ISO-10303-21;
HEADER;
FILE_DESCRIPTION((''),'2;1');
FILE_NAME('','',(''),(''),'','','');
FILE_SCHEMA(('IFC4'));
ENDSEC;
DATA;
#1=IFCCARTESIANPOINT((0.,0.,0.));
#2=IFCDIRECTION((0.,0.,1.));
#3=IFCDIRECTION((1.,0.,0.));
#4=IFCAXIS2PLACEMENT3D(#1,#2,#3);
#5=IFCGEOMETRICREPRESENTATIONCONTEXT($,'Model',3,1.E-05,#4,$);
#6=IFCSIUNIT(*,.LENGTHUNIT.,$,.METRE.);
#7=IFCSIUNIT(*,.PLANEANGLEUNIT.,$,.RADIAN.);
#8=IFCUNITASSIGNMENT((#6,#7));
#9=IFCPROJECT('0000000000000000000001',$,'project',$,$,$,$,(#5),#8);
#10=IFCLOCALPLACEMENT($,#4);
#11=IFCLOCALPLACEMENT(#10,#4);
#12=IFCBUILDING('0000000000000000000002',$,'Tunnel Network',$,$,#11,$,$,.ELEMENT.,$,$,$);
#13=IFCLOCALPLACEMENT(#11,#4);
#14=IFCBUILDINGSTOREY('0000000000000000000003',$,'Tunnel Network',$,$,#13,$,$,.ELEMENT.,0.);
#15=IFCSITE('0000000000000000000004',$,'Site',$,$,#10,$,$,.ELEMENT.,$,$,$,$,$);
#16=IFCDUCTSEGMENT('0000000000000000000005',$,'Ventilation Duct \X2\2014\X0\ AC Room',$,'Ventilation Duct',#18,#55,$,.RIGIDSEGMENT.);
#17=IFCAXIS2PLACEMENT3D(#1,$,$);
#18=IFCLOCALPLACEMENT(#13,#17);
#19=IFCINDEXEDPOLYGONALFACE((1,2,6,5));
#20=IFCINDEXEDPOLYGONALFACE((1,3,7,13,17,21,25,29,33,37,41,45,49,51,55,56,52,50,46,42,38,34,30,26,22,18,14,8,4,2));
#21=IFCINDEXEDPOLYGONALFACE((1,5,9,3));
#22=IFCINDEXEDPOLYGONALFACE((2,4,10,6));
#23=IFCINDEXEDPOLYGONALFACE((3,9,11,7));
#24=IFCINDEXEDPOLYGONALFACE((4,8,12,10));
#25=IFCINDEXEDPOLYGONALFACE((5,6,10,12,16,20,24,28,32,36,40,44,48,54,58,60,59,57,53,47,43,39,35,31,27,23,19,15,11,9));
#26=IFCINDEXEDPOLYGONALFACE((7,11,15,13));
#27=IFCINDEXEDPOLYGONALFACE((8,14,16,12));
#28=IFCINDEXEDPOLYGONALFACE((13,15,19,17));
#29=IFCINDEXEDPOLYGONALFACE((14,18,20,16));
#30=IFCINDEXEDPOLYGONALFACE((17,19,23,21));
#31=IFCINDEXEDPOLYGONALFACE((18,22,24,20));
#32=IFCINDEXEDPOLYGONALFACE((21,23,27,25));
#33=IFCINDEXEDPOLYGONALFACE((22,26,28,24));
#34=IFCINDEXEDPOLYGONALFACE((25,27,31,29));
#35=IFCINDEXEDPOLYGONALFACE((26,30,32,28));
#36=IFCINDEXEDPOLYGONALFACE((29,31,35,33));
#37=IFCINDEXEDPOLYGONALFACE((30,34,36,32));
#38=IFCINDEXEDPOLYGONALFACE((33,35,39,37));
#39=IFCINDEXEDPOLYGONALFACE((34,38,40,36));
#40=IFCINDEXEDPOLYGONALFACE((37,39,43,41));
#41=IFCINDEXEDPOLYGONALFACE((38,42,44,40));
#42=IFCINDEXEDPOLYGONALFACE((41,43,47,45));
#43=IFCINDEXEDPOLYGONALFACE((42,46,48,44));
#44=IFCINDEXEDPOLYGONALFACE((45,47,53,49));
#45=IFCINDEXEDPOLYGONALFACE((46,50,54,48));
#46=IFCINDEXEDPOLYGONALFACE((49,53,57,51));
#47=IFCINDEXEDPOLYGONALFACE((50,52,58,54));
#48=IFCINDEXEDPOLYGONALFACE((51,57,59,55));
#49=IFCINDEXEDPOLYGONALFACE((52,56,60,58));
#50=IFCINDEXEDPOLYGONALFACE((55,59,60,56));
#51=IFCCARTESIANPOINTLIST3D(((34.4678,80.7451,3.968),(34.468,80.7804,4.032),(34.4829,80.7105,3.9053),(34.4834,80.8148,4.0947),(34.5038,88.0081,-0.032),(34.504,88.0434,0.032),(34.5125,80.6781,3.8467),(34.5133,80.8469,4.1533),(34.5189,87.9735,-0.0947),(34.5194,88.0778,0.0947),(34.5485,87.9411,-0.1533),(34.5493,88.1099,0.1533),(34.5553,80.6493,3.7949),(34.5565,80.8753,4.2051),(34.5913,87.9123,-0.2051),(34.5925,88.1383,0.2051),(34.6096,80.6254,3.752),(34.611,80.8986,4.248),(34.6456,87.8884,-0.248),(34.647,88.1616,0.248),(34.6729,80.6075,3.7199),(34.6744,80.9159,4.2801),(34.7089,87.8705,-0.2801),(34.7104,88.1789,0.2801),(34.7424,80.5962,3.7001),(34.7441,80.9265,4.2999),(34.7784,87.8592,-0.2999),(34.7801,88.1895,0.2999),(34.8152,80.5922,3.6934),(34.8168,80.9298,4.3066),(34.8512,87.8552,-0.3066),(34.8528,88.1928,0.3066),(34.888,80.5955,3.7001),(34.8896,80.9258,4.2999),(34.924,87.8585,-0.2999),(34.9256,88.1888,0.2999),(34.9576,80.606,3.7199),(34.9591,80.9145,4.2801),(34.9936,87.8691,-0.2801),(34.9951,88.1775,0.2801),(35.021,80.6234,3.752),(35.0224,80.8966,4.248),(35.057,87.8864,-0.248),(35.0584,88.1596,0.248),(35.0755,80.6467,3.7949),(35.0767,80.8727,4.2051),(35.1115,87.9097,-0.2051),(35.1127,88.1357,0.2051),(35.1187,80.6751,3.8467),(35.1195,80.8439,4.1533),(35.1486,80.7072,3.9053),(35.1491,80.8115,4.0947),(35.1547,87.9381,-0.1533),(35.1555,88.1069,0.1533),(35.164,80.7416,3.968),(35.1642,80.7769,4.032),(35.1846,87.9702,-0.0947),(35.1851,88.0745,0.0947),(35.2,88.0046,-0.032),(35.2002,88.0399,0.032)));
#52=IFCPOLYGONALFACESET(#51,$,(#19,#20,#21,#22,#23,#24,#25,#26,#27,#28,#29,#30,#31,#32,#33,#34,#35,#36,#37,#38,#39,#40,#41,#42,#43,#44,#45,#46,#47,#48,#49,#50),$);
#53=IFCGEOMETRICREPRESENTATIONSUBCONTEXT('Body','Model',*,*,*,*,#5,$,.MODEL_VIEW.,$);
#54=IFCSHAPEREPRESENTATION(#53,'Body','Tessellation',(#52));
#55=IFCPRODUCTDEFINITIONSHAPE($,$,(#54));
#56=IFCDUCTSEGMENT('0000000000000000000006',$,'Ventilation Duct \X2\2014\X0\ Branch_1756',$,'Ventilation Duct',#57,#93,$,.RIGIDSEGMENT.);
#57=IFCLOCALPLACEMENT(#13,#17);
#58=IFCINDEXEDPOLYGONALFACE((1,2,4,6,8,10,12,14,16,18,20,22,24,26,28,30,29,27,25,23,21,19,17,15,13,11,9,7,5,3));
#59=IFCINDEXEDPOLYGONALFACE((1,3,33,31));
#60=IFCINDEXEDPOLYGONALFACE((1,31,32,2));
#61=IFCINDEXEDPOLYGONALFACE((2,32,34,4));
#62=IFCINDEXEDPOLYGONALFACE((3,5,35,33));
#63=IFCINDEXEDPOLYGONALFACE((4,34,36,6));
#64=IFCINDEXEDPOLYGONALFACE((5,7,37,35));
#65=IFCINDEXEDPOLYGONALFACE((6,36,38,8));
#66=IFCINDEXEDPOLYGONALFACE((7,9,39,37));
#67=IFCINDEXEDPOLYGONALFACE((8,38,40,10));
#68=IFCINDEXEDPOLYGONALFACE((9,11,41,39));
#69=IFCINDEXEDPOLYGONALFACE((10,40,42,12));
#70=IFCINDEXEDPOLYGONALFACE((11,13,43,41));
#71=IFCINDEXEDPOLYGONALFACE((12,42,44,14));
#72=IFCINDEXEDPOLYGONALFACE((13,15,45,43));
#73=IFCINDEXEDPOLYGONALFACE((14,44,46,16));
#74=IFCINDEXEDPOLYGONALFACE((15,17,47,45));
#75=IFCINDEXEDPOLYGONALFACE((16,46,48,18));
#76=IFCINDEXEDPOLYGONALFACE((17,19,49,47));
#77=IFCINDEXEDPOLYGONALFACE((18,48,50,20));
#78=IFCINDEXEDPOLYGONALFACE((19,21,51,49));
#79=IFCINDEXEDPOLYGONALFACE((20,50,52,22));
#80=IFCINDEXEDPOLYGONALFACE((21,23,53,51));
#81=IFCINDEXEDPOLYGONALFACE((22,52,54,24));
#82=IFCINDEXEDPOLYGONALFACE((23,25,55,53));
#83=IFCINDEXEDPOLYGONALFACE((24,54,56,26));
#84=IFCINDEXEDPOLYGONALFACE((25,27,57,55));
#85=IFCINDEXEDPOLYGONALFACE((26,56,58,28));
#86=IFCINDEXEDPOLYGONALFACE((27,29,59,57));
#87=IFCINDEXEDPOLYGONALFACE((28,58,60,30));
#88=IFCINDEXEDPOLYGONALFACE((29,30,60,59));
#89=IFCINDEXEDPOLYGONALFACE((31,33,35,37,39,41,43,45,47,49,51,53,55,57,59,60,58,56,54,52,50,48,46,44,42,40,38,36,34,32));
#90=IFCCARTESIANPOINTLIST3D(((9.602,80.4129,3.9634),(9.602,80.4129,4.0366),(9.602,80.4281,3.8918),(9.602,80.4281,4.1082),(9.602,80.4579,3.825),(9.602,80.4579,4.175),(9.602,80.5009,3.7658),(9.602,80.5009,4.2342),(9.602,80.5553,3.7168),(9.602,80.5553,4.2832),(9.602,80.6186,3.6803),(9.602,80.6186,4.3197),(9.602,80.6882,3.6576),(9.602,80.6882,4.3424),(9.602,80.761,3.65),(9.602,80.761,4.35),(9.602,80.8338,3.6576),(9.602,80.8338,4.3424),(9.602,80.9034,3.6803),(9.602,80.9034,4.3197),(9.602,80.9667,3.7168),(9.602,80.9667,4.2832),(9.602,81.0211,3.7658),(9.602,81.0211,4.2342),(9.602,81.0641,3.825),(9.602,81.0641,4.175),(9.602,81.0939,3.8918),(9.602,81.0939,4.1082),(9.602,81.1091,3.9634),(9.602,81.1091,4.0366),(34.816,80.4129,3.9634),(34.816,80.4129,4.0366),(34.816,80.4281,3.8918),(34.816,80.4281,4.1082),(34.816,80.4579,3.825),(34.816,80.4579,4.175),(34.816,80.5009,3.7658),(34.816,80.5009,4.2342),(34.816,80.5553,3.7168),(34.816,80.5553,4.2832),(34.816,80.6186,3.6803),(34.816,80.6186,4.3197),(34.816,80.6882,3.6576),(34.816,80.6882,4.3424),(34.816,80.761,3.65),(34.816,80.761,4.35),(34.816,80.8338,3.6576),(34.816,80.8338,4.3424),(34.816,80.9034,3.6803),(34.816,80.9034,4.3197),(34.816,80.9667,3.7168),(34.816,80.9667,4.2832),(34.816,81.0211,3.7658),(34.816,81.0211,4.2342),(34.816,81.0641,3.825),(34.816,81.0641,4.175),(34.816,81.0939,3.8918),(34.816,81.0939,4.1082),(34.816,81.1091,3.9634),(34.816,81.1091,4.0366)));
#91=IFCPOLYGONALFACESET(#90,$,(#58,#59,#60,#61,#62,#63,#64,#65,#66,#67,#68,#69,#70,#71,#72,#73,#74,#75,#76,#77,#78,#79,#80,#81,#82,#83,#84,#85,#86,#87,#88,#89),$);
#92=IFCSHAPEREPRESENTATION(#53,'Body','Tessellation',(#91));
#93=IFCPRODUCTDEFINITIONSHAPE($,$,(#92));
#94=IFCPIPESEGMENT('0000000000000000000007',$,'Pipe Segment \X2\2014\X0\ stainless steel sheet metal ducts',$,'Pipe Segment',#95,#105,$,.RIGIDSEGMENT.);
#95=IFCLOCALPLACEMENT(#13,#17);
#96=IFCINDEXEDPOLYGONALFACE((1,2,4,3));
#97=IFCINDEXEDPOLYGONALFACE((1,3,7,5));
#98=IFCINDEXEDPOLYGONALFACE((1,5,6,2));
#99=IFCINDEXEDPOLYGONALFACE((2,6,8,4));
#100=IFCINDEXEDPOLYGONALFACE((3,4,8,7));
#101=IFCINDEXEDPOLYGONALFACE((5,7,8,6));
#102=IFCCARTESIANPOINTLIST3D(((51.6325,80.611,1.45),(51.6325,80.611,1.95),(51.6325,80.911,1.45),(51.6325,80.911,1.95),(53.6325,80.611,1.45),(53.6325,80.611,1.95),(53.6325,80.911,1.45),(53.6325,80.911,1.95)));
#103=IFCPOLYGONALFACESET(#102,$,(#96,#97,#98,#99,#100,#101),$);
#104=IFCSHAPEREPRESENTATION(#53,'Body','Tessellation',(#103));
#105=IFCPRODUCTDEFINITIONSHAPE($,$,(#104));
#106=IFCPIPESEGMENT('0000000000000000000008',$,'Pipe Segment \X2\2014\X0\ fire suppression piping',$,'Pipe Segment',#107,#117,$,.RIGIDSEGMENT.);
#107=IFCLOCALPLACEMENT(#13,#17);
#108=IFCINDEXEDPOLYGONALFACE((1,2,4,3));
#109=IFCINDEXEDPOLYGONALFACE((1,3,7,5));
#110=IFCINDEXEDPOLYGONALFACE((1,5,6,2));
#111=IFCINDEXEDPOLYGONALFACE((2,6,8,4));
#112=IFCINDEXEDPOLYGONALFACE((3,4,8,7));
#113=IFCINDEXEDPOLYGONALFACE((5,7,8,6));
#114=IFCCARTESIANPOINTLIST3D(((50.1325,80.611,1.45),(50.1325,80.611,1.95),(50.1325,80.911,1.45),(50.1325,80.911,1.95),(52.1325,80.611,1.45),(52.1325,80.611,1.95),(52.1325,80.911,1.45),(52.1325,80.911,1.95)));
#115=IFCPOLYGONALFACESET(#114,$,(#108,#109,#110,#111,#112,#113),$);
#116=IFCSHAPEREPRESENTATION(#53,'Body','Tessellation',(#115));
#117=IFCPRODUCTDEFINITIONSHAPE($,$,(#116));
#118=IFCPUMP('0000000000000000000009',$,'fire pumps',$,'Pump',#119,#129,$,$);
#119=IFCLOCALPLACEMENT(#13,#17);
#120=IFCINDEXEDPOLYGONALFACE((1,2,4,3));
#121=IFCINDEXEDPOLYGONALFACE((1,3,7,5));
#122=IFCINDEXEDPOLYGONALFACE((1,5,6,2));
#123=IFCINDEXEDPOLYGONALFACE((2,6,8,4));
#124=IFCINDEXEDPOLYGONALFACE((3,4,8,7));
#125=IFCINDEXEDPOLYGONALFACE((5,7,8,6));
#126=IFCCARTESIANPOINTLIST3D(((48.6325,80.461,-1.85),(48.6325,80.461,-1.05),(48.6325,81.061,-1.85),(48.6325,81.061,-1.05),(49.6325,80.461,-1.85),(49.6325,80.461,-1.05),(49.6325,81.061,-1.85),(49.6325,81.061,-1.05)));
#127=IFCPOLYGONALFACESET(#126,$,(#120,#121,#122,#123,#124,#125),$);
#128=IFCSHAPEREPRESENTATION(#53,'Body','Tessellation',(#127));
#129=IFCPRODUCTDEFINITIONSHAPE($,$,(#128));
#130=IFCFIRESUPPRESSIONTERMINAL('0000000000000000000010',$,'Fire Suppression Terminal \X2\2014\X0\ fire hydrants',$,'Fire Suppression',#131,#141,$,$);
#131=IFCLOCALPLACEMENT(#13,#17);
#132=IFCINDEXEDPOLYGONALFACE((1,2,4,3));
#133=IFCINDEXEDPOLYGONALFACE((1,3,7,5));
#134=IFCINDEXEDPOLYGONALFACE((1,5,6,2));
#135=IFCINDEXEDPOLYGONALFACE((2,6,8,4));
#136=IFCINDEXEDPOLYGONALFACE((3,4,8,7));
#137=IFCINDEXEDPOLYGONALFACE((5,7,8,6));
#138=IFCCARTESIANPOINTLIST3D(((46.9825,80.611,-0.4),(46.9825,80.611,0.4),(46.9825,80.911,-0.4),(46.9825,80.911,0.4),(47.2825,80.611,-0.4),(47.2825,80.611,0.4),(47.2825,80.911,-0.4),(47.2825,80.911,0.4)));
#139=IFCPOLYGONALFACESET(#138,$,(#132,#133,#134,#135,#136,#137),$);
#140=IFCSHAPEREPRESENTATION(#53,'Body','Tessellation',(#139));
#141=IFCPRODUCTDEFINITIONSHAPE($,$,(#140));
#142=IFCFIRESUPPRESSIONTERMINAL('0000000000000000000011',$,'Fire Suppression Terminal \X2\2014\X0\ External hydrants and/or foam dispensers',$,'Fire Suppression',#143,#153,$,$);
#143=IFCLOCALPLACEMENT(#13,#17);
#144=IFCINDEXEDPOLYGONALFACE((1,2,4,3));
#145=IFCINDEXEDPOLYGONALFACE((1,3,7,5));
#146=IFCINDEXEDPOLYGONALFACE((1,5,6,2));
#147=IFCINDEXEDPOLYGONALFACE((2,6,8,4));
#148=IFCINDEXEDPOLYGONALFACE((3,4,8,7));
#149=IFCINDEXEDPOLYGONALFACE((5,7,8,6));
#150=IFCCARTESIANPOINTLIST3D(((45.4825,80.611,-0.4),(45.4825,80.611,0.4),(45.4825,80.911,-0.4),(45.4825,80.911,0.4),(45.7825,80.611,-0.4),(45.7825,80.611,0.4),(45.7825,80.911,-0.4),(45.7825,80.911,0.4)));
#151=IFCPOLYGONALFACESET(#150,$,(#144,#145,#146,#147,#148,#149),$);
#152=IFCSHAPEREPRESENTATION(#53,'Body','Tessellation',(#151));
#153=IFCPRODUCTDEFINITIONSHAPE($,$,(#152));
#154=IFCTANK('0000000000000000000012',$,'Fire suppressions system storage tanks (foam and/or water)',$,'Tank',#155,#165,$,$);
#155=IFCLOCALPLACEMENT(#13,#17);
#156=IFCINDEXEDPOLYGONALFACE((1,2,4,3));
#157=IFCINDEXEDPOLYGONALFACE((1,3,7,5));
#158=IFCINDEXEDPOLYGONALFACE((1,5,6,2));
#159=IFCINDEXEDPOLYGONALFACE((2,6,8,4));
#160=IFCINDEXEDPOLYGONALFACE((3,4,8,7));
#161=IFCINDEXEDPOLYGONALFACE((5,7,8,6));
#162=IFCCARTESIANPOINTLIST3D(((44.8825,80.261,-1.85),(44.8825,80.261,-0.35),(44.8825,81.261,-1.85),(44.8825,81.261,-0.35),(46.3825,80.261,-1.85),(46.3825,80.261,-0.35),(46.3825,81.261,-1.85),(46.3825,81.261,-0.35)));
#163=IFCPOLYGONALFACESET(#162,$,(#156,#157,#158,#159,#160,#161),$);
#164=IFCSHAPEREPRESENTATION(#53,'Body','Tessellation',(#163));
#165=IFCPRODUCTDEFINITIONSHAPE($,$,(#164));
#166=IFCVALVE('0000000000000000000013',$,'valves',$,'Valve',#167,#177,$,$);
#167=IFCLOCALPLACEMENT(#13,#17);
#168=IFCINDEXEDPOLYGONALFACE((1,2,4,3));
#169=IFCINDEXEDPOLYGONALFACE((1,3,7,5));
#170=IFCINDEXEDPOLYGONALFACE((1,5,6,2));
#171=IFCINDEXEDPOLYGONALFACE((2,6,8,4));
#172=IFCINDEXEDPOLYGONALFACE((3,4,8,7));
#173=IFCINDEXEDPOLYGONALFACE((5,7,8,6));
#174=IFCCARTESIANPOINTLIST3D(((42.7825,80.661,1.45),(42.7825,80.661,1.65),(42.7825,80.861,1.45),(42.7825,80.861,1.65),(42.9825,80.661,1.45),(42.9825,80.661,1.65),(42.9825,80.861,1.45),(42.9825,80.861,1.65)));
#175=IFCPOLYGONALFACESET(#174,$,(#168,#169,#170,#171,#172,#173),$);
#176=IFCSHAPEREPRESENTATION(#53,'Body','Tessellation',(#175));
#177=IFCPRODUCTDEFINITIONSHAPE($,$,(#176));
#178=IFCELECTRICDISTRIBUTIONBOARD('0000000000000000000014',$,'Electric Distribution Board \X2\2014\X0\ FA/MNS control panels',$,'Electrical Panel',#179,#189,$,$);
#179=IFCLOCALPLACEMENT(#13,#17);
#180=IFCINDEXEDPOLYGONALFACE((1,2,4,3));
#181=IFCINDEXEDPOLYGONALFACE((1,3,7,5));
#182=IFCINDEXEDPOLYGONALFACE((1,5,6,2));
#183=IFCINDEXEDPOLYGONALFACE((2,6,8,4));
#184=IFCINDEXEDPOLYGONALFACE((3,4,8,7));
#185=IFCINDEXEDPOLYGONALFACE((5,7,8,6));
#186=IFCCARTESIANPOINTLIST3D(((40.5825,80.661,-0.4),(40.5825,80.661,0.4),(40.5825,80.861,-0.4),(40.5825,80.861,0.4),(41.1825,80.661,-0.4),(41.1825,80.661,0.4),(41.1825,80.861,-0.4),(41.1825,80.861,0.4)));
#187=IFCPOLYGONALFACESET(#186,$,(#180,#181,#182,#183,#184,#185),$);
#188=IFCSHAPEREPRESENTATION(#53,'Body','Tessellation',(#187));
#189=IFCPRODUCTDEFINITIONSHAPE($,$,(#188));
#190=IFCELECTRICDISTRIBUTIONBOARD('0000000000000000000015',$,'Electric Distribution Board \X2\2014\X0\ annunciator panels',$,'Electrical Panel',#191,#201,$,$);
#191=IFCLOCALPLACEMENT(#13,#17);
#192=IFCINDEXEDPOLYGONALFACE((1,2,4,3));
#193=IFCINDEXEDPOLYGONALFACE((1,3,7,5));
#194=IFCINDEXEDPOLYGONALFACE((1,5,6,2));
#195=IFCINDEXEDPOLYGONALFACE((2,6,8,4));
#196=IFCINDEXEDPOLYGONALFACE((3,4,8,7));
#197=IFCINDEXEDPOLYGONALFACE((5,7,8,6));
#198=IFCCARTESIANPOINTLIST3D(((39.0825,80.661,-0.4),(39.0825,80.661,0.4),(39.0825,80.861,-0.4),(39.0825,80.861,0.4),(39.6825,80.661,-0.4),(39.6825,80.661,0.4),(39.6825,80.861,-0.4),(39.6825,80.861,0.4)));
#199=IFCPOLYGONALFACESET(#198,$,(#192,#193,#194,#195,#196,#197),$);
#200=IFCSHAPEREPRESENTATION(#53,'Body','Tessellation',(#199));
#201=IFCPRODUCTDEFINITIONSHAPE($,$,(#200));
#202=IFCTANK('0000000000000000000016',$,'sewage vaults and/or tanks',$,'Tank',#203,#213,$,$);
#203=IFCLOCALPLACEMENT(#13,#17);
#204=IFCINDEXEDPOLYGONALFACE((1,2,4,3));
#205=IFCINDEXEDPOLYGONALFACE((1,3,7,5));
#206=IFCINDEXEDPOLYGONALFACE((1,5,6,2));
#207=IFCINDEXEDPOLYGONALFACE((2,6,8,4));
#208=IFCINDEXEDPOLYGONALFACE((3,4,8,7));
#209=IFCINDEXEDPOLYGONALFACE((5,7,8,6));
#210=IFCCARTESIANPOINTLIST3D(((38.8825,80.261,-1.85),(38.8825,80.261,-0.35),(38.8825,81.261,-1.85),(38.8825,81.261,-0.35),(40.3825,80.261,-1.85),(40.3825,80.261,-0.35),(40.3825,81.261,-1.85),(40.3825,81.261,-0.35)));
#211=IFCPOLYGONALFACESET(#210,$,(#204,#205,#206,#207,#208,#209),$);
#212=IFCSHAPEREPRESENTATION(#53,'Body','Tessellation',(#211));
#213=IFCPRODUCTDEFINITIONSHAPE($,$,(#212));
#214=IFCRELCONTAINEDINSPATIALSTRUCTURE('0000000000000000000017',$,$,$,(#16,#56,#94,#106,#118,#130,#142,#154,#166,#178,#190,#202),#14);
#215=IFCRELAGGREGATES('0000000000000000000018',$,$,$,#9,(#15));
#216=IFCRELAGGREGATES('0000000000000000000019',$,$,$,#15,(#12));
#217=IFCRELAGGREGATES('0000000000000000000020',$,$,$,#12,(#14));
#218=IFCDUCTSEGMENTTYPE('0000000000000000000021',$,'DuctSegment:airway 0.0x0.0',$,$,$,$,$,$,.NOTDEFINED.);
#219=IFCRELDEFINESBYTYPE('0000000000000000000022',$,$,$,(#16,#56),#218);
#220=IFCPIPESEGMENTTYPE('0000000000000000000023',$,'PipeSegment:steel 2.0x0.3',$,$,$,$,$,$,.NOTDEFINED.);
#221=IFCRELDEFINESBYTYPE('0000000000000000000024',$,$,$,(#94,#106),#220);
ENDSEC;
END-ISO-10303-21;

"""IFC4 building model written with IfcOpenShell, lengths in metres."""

from ifc_helpers import new_model, si_unit, frame, origin_with_axes, origin_2d_with_axis, place, context, subcontext, project, spatial, rectangle, circle, extrude, type_object, element, save


model = new_model("IFC4")

# Units and contexts
model_context = context("Model", 3, precision=1e-05, world=origin_with_axes())
body_context = subcontext(model_context, "Body", "Model", "MODEL_VIEW")
ifc_project = project(units=[si_unit("LENGTHUNIT", "METRE"), si_unit("PLANEANGLEUNIT", "RADIAN")], contexts=[model_context])

# Site, building, storey
site_placement = place(None, origin_with_axes())
site = spatial("IfcSite", under=ifc_project, at=site_placement, Name="Site", CompositionType="ELEMENT")
building_placement = place(site_placement, origin_with_axes())
building = spatial("IfcBuilding", under=site, at=building_placement, Name="Tunnel Network", CompositionType="ELEMENT")
storey_placement = place(building_placement, origin_with_axes())
storey = spatial("IfcBuildingStorey", under=building, at=storey_placement, Name="Tunnel Network", CompositionType="ELEMENT", Elevation=0.0)

# Duct segments
duct_segment_type_1 = type_object("IfcDuctSegmentType", Name="DuctSegment:airway 0.0x0.0")
duct_segment_1_placement = place(storey_placement, frame((34.852, 88.024, 0.0), z_axis=(-0.004342, -0.875935, 0.482409), x_axis=(0.002391, 0.482404, 0.875946)))
element("IfcDuctSegment", 1, at=duct_segment_1_placement, inside=storey, type_object=duct_segment_type_1, Name="Ventilation Duct — AC Room", ObjectType="Ventilation Duct", PredefinedType="RIGIDSEGMENT", context=body_context, shape_type="SweptSolid", body=[
    extrude(circle(Radius=0.35, at=origin_2d_with_axis()), origin_with_axes(), (0.0, 0.0, 1.0), 8.2917),
])
duct_segment_2_placement = place(storey_placement, frame((34.816, 80.761, 4.0), z_axis=(-1.0, 0.0, 0.0), x_axis=(0.0, 0.0, 1.0)))
element("IfcDuctSegment", 2, at=duct_segment_2_placement, inside=storey, type_object=duct_segment_type_1, Name="Ventilation Duct — Branch_1756", ObjectType="Ventilation Duct", PredefinedType="RIGIDSEGMENT", context=body_context, shape_type="SweptSolid", body=[
    extrude(circle(Radius=0.35, at=origin_2d_with_axis()), origin_with_axes(), (0.0, 0.0, 1.0), 25.214),
])

# Pipe segments
pipe_segment_type = type_object("IfcPipeSegmentType", Name="PipeSegment:steel 2.0x0.3")
for number, where, z_axis, x_axis, name in (
    (3, (52.6325, 80.761, 1.45), (0.0, 0.0, 1.0), (1.0, 0.0, 0.0), "Pipe Segment — stainless steel sheet metal ducts"),
    (4, (51.1325, 80.761, 1.45), (0.0, 0.0, 1.0), (1.0, 0.0, 0.0), "Pipe Segment — fire suppression piping"),
):
    element("IfcPipeSegment", number, at=place(storey_placement, frame(where, z_axis=z_axis, x_axis=x_axis)), inside=storey, type_object=pipe_segment_type, Name=name, ObjectType="Pipe Segment", PredefinedType="RIGIDSEGMENT", context=body_context, shape_type="SweptSolid", body=[
        extrude(rectangle(XDim=2.0, YDim=0.3, at=origin_2d_with_axis()), origin_with_axes(), (0.0, 0.0, 1.0), 0.5),
    ])

# Pump
pump_placement = place(storey_placement, frame((49.1325, 80.761, -1.85), z_axis=(0.0, 0.0, 1.0), x_axis=(1.0, 0.0, 0.0)))
element("IfcPump", 5, at=pump_placement, inside=storey, Name="fire pumps", ObjectType="Pump", context=body_context, shape_type="SweptSolid", body=[
    extrude(rectangle(XDim=1.0, YDim=0.6, at=origin_2d_with_axis()), origin_with_axes(), (0.0, 0.0, 1.0), 0.8),
])

# Fire suppression terminals
for number, where, z_axis, x_axis, name in (
    (6, (47.1325, 80.761, -0.4), (0.0, 0.0, 1.0), (1.0, 0.0, 0.0), "Fire Suppression Terminal — fire hydrants"),
    (7, (45.6325, 80.761, -0.4), (0.0, 0.0, 1.0), (1.0, 0.0, 0.0), "Fire Suppression Terminal — External hydrants and/or foam dispensers"),
):
    element("IfcFireSuppressionTerminal", number, at=place(storey_placement, frame(where, z_axis=z_axis, x_axis=x_axis)), inside=storey, Name=name, ObjectType="Fire Suppression", context=body_context, shape_type="SweptSolid", body=[
        extrude(rectangle(XDim=0.3, YDim=0.3, at=origin_2d_with_axis()), origin_with_axes(), (0.0, 0.0, 1.0), 0.8),
    ])

# Tank
tank_1_placement = place(storey_placement, frame((45.6325, 80.761, -1.85), z_axis=(0.0, 0.0, 1.0), x_axis=(1.0, 0.0, 0.0)))
element("IfcTank", 8, at=tank_1_placement, inside=storey, Name="Fire suppressions system storage tanks (foam and/or water)", ObjectType="Tank", context=body_context, shape_type="SweptSolid", body=[
    extrude(rectangle(XDim=1.5, YDim=1.0, at=origin_2d_with_axis()), origin_with_axes(), (0.0, 0.0, 1.0), 1.5),
])

# Valve
valve_placement = place(storey_placement, frame((42.8825, 80.761, 1.45), z_axis=(0.0, 0.0, 1.0), x_axis=(1.0, 0.0, 0.0)))
element("IfcValve", 9, at=valve_placement, inside=storey, Name="valves", ObjectType="Valve", context=body_context, shape_type="SweptSolid", body=[
    extrude(rectangle(XDim=0.2, YDim=0.2, at=origin_2d_with_axis()), origin_with_axes(), (0.0, 0.0, 1.0), 0.2),
])

# Electric distribution boards
for number, where, z_axis, x_axis, name in (
    (10, (40.8825, 80.761, -0.4), (0.0, 0.0, 1.0), (1.0, 0.0, 0.0), "Electric Distribution Board — FA/MNS control panels"),
    (11, (39.3825, 80.761, -0.4), (0.0, 0.0, 1.0), (1.0, 0.0, 0.0), "Electric Distribution Board — annunciator panels"),
):
    element("IfcElectricDistributionBoard", number, at=place(storey_placement, frame(where, z_axis=z_axis, x_axis=x_axis)), inside=storey, Name=name, ObjectType="Electrical Panel", context=body_context, shape_type="SweptSolid", body=[
        extrude(rectangle(XDim=0.6, YDim=0.2, at=origin_2d_with_axis()), origin_with_axes(), (0.0, 0.0, 1.0), 0.8),
    ])

# Tank
tank_2_placement = place(storey_placement, frame((39.6325, 80.761, -1.85), z_axis=(0.0, 0.0, 1.0), x_axis=(1.0, 0.0, 0.0)))
element("IfcTank", 12, at=tank_2_placement, inside=storey, Name="sewage vaults and/or tanks", ObjectType="Tank", context=body_context, shape_type="SweptSolid", body=[
    extrude(rectangle(XDim=1.5, YDim=1.0, at=origin_2d_with_axis()), origin_with_axes(), (0.0, 0.0, 1.0), 1.5),
])

save(model, "model.ifc")
